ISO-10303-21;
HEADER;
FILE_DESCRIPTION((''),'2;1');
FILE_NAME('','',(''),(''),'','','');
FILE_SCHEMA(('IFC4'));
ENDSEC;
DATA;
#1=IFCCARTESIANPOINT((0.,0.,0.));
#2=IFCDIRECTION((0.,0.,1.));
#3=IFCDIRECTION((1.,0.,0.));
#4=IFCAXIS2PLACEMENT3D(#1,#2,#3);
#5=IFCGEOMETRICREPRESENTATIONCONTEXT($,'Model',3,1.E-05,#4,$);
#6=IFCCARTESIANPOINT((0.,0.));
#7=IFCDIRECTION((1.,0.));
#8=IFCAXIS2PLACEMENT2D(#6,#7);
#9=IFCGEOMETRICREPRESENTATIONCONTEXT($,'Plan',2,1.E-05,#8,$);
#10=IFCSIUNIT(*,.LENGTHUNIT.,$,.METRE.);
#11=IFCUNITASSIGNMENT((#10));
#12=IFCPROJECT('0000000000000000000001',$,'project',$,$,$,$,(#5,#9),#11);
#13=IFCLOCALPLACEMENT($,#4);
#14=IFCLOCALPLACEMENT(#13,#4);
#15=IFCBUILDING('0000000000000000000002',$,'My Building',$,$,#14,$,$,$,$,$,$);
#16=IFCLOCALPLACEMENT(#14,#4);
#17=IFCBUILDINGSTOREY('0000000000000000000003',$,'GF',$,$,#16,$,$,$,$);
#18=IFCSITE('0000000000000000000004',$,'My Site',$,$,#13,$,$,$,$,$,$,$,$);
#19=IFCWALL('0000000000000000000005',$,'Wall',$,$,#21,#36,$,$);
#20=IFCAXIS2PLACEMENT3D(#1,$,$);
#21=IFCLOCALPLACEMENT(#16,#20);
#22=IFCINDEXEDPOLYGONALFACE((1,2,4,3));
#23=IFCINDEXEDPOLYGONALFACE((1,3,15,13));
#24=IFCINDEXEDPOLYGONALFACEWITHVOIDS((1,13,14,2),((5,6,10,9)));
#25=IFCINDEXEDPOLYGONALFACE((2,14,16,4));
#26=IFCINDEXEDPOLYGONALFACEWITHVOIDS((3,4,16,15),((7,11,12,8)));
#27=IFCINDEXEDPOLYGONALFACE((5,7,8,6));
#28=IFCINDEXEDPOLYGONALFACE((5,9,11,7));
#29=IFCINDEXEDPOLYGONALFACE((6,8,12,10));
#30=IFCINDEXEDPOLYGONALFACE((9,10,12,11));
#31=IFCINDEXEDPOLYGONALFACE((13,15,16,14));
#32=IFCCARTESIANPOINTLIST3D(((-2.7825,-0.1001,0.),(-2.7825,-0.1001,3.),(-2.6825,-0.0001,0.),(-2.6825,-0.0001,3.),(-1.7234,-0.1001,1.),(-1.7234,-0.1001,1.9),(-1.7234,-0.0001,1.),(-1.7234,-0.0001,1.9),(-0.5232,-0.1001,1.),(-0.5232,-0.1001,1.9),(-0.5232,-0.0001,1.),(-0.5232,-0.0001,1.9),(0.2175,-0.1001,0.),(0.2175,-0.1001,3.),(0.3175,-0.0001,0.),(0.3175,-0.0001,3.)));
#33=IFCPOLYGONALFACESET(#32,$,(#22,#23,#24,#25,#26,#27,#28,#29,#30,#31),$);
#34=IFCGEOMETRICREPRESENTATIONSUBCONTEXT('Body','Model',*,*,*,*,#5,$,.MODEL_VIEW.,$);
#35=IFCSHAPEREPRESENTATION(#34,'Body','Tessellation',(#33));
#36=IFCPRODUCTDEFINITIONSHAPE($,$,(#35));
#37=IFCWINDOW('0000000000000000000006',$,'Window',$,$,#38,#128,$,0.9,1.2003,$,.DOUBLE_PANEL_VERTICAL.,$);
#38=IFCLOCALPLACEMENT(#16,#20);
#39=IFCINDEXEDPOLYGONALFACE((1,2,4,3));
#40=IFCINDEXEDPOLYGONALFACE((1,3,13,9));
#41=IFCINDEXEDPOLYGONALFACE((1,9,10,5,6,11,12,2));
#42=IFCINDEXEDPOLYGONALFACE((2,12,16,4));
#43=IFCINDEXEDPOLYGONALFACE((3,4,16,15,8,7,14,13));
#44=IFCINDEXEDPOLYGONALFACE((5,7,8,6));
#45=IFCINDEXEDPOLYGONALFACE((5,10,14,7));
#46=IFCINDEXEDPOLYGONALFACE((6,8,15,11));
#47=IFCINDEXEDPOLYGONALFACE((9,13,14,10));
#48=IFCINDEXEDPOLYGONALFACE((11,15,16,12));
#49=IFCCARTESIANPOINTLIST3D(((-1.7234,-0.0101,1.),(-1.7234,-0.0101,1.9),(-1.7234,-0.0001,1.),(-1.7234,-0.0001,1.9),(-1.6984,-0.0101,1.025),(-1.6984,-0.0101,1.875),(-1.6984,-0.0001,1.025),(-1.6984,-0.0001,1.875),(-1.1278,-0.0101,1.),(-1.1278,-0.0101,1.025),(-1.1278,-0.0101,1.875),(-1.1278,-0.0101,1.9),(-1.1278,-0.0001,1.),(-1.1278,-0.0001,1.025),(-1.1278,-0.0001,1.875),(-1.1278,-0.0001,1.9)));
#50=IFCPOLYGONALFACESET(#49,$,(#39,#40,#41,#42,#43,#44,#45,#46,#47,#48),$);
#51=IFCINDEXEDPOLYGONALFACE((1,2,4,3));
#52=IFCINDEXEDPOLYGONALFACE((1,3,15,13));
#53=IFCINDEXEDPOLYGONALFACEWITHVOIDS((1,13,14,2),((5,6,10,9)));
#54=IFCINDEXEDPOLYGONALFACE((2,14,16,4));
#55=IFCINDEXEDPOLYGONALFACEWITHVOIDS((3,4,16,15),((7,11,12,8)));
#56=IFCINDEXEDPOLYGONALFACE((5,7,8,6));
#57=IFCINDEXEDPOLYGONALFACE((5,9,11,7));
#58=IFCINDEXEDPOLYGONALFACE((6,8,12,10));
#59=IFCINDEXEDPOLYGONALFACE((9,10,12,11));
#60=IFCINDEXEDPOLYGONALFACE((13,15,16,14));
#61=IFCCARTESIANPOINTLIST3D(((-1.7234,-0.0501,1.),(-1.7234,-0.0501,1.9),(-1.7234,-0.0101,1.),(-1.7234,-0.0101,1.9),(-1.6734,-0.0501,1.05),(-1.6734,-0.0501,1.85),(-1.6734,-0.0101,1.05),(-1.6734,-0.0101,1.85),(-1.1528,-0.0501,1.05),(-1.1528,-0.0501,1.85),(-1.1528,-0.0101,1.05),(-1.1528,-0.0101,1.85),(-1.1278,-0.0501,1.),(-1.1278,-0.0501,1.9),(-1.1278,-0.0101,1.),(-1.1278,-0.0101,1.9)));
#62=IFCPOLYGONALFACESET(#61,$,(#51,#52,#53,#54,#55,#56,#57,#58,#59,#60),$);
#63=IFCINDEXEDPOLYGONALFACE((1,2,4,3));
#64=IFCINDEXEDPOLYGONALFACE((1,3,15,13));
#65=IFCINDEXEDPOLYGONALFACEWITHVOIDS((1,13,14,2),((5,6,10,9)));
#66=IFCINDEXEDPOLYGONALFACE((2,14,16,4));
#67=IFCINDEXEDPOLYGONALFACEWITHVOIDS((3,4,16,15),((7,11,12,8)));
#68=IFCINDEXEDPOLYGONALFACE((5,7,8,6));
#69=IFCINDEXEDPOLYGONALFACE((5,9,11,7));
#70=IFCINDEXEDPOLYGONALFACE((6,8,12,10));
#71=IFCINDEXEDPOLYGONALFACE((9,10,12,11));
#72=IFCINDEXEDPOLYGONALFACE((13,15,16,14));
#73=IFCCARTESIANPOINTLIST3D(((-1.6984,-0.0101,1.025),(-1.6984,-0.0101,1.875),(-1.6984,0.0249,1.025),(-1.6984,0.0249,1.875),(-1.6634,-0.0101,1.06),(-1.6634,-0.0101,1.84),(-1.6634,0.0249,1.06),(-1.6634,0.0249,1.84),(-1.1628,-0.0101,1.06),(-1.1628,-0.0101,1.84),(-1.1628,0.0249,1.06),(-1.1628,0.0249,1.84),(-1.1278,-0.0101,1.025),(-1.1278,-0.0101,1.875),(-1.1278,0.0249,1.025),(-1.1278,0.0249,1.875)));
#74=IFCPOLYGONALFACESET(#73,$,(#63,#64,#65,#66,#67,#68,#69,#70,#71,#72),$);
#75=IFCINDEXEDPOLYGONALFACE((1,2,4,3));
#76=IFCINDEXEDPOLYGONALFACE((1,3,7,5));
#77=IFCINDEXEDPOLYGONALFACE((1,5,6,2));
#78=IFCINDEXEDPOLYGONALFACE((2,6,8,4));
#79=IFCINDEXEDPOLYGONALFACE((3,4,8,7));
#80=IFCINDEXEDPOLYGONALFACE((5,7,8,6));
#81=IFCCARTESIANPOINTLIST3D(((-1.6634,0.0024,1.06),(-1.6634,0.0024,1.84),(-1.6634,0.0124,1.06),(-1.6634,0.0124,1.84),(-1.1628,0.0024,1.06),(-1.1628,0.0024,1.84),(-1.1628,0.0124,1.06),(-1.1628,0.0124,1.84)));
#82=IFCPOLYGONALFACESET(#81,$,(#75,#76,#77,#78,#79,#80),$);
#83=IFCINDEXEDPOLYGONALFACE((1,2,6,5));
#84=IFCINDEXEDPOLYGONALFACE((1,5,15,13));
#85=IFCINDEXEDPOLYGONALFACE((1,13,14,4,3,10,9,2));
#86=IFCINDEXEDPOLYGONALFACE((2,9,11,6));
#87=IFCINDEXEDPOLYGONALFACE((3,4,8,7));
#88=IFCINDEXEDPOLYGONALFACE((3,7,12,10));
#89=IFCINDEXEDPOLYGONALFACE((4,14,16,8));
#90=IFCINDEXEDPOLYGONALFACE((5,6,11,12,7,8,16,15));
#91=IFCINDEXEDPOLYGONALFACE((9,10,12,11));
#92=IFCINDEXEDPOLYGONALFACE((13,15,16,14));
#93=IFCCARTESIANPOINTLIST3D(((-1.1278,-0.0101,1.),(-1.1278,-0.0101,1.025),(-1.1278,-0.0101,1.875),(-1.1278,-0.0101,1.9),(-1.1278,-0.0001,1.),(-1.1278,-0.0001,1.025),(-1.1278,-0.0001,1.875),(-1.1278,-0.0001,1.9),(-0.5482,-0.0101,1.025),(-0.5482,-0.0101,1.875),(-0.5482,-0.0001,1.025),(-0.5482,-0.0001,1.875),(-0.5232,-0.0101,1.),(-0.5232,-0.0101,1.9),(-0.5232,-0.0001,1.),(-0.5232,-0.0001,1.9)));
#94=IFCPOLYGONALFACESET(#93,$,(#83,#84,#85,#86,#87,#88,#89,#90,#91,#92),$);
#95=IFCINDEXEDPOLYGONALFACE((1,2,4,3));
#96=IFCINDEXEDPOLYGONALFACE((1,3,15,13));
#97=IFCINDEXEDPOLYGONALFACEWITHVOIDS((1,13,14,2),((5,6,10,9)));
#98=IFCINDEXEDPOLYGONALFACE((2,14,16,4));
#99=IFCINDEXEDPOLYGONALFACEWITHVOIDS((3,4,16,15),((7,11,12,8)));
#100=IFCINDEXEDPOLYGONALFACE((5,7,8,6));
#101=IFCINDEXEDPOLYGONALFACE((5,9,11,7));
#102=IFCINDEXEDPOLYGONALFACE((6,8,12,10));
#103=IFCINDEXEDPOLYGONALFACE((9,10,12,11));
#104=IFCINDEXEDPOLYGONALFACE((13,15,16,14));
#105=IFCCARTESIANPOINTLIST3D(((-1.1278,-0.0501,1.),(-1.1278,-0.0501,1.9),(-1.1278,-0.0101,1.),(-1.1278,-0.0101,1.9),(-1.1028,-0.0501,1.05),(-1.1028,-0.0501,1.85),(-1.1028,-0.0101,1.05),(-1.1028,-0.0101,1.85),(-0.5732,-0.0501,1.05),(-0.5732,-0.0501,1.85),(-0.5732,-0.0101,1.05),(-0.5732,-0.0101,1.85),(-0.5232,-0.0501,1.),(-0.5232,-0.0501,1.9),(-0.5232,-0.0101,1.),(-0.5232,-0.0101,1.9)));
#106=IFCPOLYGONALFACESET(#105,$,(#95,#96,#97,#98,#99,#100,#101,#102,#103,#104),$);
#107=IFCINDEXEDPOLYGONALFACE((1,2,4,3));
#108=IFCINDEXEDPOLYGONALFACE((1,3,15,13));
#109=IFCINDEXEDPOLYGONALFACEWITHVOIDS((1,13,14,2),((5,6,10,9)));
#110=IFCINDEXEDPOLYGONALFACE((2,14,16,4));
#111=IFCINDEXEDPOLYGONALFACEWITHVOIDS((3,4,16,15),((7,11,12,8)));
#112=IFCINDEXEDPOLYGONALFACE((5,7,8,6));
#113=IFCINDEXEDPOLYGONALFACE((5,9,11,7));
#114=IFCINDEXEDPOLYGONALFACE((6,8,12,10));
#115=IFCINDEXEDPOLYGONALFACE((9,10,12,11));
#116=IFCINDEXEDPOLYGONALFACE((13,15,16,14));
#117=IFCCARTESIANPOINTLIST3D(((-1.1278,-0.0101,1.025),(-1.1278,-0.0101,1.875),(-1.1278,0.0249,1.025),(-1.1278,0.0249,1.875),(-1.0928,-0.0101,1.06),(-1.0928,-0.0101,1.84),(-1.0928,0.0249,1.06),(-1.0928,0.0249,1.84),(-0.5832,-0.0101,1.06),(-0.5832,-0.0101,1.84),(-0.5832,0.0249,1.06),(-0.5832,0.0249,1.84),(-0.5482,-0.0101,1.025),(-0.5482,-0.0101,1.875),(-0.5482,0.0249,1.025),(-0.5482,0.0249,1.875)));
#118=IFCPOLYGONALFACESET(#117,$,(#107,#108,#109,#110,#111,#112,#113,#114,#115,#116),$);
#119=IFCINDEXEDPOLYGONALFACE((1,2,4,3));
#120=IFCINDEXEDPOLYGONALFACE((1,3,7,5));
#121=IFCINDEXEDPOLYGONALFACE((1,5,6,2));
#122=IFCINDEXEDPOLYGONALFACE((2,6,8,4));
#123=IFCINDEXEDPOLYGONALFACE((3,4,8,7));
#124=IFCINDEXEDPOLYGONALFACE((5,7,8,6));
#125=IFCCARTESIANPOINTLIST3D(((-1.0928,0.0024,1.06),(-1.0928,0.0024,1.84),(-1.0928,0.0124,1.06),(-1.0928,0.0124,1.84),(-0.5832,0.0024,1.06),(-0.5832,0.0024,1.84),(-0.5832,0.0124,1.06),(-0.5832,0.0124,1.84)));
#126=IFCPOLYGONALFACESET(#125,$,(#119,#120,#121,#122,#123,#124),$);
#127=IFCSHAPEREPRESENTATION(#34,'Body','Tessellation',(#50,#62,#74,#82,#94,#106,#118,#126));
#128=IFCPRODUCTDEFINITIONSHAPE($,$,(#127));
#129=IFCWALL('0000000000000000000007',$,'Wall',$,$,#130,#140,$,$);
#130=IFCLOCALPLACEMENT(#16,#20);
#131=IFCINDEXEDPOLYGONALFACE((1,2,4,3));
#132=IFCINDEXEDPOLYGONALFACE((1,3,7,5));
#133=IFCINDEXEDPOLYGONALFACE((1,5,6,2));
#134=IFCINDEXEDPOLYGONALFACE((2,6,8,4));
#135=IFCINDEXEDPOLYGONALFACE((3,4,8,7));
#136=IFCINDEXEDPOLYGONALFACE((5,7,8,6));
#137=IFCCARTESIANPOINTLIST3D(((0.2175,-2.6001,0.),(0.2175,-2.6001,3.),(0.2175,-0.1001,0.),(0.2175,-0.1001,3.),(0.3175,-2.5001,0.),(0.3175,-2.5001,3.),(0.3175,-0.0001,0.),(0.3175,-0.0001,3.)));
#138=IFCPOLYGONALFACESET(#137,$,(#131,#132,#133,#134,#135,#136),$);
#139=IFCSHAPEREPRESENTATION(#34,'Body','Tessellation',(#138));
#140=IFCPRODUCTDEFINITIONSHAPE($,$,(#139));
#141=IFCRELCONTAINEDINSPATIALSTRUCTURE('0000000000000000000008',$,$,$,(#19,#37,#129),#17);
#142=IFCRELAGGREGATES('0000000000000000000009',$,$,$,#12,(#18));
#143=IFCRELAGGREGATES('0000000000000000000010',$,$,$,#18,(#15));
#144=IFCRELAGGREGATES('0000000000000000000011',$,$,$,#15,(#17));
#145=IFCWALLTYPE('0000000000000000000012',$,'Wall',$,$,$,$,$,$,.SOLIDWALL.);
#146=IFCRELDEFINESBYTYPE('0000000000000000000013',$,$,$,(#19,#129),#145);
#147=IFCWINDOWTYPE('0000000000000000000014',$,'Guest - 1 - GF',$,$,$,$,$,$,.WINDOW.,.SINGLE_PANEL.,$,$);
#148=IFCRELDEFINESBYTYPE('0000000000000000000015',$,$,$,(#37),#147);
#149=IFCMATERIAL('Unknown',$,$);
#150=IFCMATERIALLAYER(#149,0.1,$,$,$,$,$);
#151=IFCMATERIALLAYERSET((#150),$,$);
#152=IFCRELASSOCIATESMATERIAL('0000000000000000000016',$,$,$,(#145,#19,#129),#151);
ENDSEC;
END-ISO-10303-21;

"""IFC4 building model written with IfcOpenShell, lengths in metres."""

from ifc_helpers import new_model, entity, si_unit, frame, origin_with_axes, origin_2d_with_axis, place, context, subcontext, project, spatial, line, indexed_curve, outline, extrude, shape, source, transform, mapped, material, layer, layer_set, layer_usage, type_object, type_shapes, element, fill, save


model = new_model("IFC4")

# Units and contexts
model_context = context("Model", 3, precision=1e-05, world=origin_with_axes())
plan_context = context("Plan", 2, precision=1e-05, world=origin_2d_with_axis())
body_context_1 = subcontext(model_context, "Body", "Model", "MODEL_VIEW")
body_context_2 = subcontext(plan_context, "Body", "Plan", "PLAN_VIEW")
ifc_project = project(units=[si_unit("LENGTHUNIT", "METRE")], contexts=[model_context, plan_context])

# Site, building, storey
site_placement = place(None, origin_with_axes())
site = spatial("IfcSite", under=ifc_project, at=site_placement, Name="My Site")
building_placement = place(site_placement, origin_with_axes())
building = spatial("IfcBuilding", under=site, at=building_placement, Name="My Building")
storey_placement = place(building_placement, origin_with_axes())
storey = spatial("IfcBuildingStorey", under=building, at=storey_placement, Name="GF")

# Shared definitions
ifc_material_1 = material(Name="Unknown")

# Shared definitions
ifc_layer_1 = layer(ifc_material_1, 0.1)
ifc_layer_set_1 = layer_set([ifc_layer_1])
wall_type = type_object("IfcWallType", Name="Wall", PredefinedType="SOLIDWALL", material=ifc_layer_set_1)

# Wall, opening, window
ifc_layer_usage_1 = layer_usage(ifc_layer_set_1, "AXIS2", "POSITIVE", 0.0)
wall_1_placement = place(storey_placement, frame((-2.7825, -0.1001, 0.0), z_axis=(0.0, 0.0, 1.0), x_axis=(1.0, 0.0, 0.0)))
wall_1 = element("IfcWall", 1, at=wall_1_placement, inside=storey, type_object=wall_type, material=ifc_layer_usage_1, Name="Wall", context=body_context_1, shape_type="SweptSolid", body=[
    extrude(outline(indexed_curve([(0.0, 0.0), (0.1, 0.1), (3.1, 0.1), (3.0, 0.0)], segments=[line(1, 2, 3, 4, 1)])), origin_with_axes(), (0.0, 0.0, 1.0), 3.0),
])
shared_shape_1 = source(origin_with_axes(), body_context_1, "Body", "SweptSolid", [
    extrude(outline(indexed_curve([(0.0, 0.0), (1.2003, 0.0), (1.2003, 0.9), (0.0, 0.9)], segments=[line(1, 2, 3, 4, 1)])), frame((0.0, -0.6, 0.0), z_axis=(0.0, -1.0, 0.0), x_axis=(1.0, 0.0, 0.0)), (0.0, 0.0, -1.0), 1.2),
])
opening_1_placement = place(wall_1_placement, frame((1.0591, 0.0, 1.0), z_axis=(0.0, 0.0, 1.0), x_axis=(1.0, 0.0, 0.0)))
opening_1 = element("IfcOpeningElement", 2, at=opening_1_placement, cuts=wall_1, PredefinedType="OPENING", context=body_context_1, shape_type="MappedRepresentation", body=[
    mapped(shared_shape_1, transform((0.0, 0.0, 0.0), x_axis=(1.0, 0.0, 0.0), y_axis=(0.0, 1.0, 0.0), z_axis=(0.0, 0.0, 1.0), scale=1.0)),
])
window_type_1 = type_object("IfcWindowType", Name="Guest - 1 - GF", PartitioningType="SINGLE_PANEL", PredefinedType="WINDOW")
shared_shape_2 = source(origin_with_axes(), body_context_1, "Body", "SweptSolid", [
    extrude(outline(indexed_curve([(0.5956, 0.0), (0.0, 0.0), (0.0, 0.9), (0.5956, 0.9), (0.5956, 0.875), (0.025, 0.875), (0.025, 0.025), (0.5956, 0.025)], segments=[line(1, 2, 3, 4, 5, 6, 7, 8, 1)])), frame((0.0, 0.09, 0.0), z_axis=(0.0, -1.0, 0.0), x_axis=(1.0, 0.0, 0.0)), (0.0, 0.0, -1.0), 0.01),
    extrude(outline(indexed_curve([(0.0, 0.0), (0.5956, 0.0), (0.5956, 0.9), (0.0, 0.9)], segments=[line(1, 2, 3, 4, 1)]), holes=[indexed_curve([(0.05, 0.05), (0.5706, 0.05), (0.5706, 0.85), (0.05, 0.85)], segments=[line(1, 2, 3, 4, 1)])]), frame((0.0, 0.05, 0.0), z_axis=(0.0, -1.0, 0.0), x_axis=(1.0, 0.0, 0.0)), (0.0, 0.0, -1.0), 0.04),
    extrude(outline(indexed_curve([(0.0, 0.0), (0.5706, 0.0), (0.5706, 0.85), (0.0, 0.85)], segments=[line(1, 2, 3, 4, 1)]), holes=[indexed_curve([(0.035, 0.035), (0.5356, 0.035), (0.5356, 0.815), (0.035, 0.815)], segments=[line(1, 2, 3, 4, 1)])]), frame((0.025, 0.09, 0.025), z_axis=(0.0, -1.0, 0.0), x_axis=(1.0, 0.0, 0.0)), (0.0, 0.0, -1.0), 0.035),
    extrude(outline(indexed_curve([(0.035, 0.035), (0.5356, 0.035), (0.5356, 0.815), (0.035, 0.815)], segments=[line(1, 2, 3, 4, 1)])), frame((0.025, 0.1025, 0.025), z_axis=(0.0, -1.0, 0.0), x_axis=(1.0, 0.0, 0.0)), (0.0, 0.0, -1.0), 0.01),
    extrude(outline(indexed_curve([(0.0, 0.9), (0.6046, 0.9), (0.6046, 0.0), (0.0, 0.0), (0.0, 0.025), (0.5796, 0.025), (0.5796, 0.875), (0.0, 0.875)], segments=[line(1, 2, 3, 4, 5, 6, 7, 8, 1)])), frame((0.5956, 0.09, 0.0), z_axis=(0.0, -1.0, 0.0), x_axis=(1.0, 0.0, 0.0)), (0.0, 0.0, -1.0), 0.01),
    extrude(outline(indexed_curve([(0.0, 0.0), (0.6046, 0.0), (0.6046, 0.9), (0.0, 0.9)], segments=[line(1, 2, 3, 4, 1)]), holes=[indexed_curve([(0.025, 0.05), (0.5546, 0.05), (0.5546, 0.85), (0.025, 0.85)], segments=[line(1, 2, 3, 4, 1)])]), frame((0.5956, 0.05, 0.0), z_axis=(0.0, -1.0, 0.0), x_axis=(1.0, 0.0, 0.0)), (0.0, 0.0, -1.0), 0.04),
    extrude(outline(indexed_curve([(0.0, 0.0), (0.5796, 0.0), (0.5796, 0.85), (0.0, 0.85)], segments=[line(1, 2, 3, 4, 1)]), holes=[indexed_curve([(0.035, 0.035), (0.5446, 0.035), (0.5446, 0.815), (0.035, 0.815)], segments=[line(1, 2, 3, 4, 1)])]), frame((0.5956, 0.09, 0.025), z_axis=(0.0, -1.0, 0.0), x_axis=(1.0, 0.0, 0.0)), (0.0, 0.0, -1.0), 0.035),
    extrude(outline(indexed_curve([(0.035, 0.035), (0.5446, 0.035), (0.5446, 0.815), (0.035, 0.815)], segments=[line(1, 2, 3, 4, 1)])), frame((0.5956, 0.1025, 0.025), z_axis=(0.0, -1.0, 0.0), x_axis=(1.0, 0.0, 0.0)), (0.0, 0.0, -1.0), 0.01),
])
shared_shape_3 = source(origin_with_axes(), body_context_2, "Body", "Curve2D", [
    entity("IfcIndexedPolyCurve", entity("IfcCartesianPointList2D", [[0.05, 0.05], [0.5706, 0.05]])),
    entity("IfcIndexedPolyCurve", entity("IfcCartesianPointList2D", [[0.0, 0.1], [0.025, 0.1], [0.025, 0.09], [0.05, 0.09], [0.05, 0.05], [0.0, 0.05]]), [entity("IfcLineIndex", [1, 2, 3, 4, 5, 6, 1])]),
    entity("IfcIndexedPolyCurve", entity("IfcCartesianPointList2D", [[0.5956, 0.1], [0.5956, 0.1], [0.5956, 0.09], [0.5706, 0.09], [0.5706, 0.05], [0.5956, 0.05]])),
    entity("IfcIndexedPolyCurve", entity("IfcCartesianPointList2D", [[0.025, 0.09], [0.06, 0.09], [0.06, 0.125], [0.025, 0.125]]), [entity("IfcLineIndex", [1, 2, 3, 4, 1])]),
    entity("IfcIndexedPolyCurve", entity("IfcCartesianPointList2D", [[0.5956, 0.09], [0.5606, 0.09], [0.5606, 0.125], [0.5956, 0.125]]), [entity("IfcLineIndex", [1, 2, 3, 4, 1])]),
    entity("IfcIndexedPolyCurve", entity("IfcCartesianPointList2D", [[0.06, 0.09], [0.5606, 0.09]])),
    entity("IfcIndexedPolyCurve", entity("IfcCartesianPointList2D", [[0.06, 0.125], [0.5606, 0.125]])),
    entity("IfcIndexedPolyCurve", entity("IfcCartesianPointList2D", [[0.06, 0.1075], [0.5606, 0.1075]])),
    entity("IfcIndexedPolyCurve", entity("IfcCartesianPointList2D", [[0.6206, 0.05], [1.1503, 0.05]])),
    entity("IfcIndexedPolyCurve", entity("IfcCartesianPointList2D", [[0.5956, 0.1], [0.5956, 0.1], [0.5956, 0.09], [0.6206, 0.09], [0.6206, 0.05], [0.5956, 0.05]])),
    entity("IfcIndexedPolyCurve", entity("IfcCartesianPointList2D", [[1.2003, 0.1], [1.1753, 0.1], [1.1753, 0.09], [1.1503, 0.09], [1.1503, 0.05], [1.2003, 0.05]]), [entity("IfcLineIndex", [1, 2, 3, 4, 5, 6, 1])]),
    entity("IfcIndexedPolyCurve", entity("IfcCartesianPointList2D", [[0.5956, 0.09], [0.6306, 0.09], [0.6306, 0.125], [0.5956, 0.125]]), [entity("IfcLineIndex", [1, 2, 3, 4, 1])]),
    entity("IfcIndexedPolyCurve", entity("IfcCartesianPointList2D", [[1.1753, 0.09], [1.1403, 0.09], [1.1403, 0.125], [1.1753, 0.125]]), [entity("IfcLineIndex", [1, 2, 3, 4, 1])]),
    entity("IfcIndexedPolyCurve", entity("IfcCartesianPointList2D", [[0.6306, 0.09], [1.1403, 0.09]])),
    entity("IfcIndexedPolyCurve", entity("IfcCartesianPointList2D", [[0.6306, 0.125], [1.1403, 0.125]])),
    entity("IfcIndexedPolyCurve", entity("IfcCartesianPointList2D", [[0.6306, 0.1075], [1.1403, 0.1075]])),
])
type_shapes(window_type_1, [shared_shape_2, shared_shape_3])
window_1_placement = place(opening_1_placement, frame((0.0, 0.0, 0.0), z_axis=(0.0, 0.0, 1.0), x_axis=(1.0, 0.0, 0.0)))
window_1 = element("IfcWindow", 3, at=window_1_placement, inside=storey, type_object=window_type_1, Name="Window", OverallHeight=0.9, OverallWidth=1.2003, PartitioningType="DOUBLE_PANEL_VERTICAL", shapes=[
    shape(body_context_1, "Body", "MappedRepresentation", [mapped(shared_shape_2, transform((0.0, 0.0, 0.0), x_axis=(1.0, 0.0, 0.0), y_axis=(0.0, 1.0, 0.0), z_axis=(0.0, 0.0, 1.0), scale=1.0))]),
    shape(body_context_2, "Body", "MappedRepresentation", [mapped(shared_shape_3, transform((0.0, 0.0, 0.0), x_axis=(1.0, 0.0, 0.0), y_axis=(0.0, 1.0, 0.0), z_axis=(0.0, 0.0, 1.0), scale=1.0))]),
])
fill(opening_1, window_1)

# Wall
ifc_layer_usage_2 = layer_usage(ifc_layer_set_1, "AXIS2", "POSITIVE", 0.0)
wall_2_placement = place(storey_placement, frame((0.2175, -0.1001, 0.0), z_axis=(0.0, 0.0, 1.0), x_axis=(0.0, -1.0, 0.0)))
element("IfcWall", 4, at=wall_2_placement, inside=storey, type_object=wall_type, material=ifc_layer_usage_2, Name="Wall", context=body_context_1, shape_type="SweptSolid", body=[
    extrude(outline(indexed_curve([(0.0, 0.0), (-0.1, 0.1), (2.4, 0.1), (2.5, 0.0)], segments=[line(1, 2, 3, 4, 1)])), origin_with_axes(), (0.0, 0.0, 1.0), 3.0),
])

save(model, "model.ifc")
